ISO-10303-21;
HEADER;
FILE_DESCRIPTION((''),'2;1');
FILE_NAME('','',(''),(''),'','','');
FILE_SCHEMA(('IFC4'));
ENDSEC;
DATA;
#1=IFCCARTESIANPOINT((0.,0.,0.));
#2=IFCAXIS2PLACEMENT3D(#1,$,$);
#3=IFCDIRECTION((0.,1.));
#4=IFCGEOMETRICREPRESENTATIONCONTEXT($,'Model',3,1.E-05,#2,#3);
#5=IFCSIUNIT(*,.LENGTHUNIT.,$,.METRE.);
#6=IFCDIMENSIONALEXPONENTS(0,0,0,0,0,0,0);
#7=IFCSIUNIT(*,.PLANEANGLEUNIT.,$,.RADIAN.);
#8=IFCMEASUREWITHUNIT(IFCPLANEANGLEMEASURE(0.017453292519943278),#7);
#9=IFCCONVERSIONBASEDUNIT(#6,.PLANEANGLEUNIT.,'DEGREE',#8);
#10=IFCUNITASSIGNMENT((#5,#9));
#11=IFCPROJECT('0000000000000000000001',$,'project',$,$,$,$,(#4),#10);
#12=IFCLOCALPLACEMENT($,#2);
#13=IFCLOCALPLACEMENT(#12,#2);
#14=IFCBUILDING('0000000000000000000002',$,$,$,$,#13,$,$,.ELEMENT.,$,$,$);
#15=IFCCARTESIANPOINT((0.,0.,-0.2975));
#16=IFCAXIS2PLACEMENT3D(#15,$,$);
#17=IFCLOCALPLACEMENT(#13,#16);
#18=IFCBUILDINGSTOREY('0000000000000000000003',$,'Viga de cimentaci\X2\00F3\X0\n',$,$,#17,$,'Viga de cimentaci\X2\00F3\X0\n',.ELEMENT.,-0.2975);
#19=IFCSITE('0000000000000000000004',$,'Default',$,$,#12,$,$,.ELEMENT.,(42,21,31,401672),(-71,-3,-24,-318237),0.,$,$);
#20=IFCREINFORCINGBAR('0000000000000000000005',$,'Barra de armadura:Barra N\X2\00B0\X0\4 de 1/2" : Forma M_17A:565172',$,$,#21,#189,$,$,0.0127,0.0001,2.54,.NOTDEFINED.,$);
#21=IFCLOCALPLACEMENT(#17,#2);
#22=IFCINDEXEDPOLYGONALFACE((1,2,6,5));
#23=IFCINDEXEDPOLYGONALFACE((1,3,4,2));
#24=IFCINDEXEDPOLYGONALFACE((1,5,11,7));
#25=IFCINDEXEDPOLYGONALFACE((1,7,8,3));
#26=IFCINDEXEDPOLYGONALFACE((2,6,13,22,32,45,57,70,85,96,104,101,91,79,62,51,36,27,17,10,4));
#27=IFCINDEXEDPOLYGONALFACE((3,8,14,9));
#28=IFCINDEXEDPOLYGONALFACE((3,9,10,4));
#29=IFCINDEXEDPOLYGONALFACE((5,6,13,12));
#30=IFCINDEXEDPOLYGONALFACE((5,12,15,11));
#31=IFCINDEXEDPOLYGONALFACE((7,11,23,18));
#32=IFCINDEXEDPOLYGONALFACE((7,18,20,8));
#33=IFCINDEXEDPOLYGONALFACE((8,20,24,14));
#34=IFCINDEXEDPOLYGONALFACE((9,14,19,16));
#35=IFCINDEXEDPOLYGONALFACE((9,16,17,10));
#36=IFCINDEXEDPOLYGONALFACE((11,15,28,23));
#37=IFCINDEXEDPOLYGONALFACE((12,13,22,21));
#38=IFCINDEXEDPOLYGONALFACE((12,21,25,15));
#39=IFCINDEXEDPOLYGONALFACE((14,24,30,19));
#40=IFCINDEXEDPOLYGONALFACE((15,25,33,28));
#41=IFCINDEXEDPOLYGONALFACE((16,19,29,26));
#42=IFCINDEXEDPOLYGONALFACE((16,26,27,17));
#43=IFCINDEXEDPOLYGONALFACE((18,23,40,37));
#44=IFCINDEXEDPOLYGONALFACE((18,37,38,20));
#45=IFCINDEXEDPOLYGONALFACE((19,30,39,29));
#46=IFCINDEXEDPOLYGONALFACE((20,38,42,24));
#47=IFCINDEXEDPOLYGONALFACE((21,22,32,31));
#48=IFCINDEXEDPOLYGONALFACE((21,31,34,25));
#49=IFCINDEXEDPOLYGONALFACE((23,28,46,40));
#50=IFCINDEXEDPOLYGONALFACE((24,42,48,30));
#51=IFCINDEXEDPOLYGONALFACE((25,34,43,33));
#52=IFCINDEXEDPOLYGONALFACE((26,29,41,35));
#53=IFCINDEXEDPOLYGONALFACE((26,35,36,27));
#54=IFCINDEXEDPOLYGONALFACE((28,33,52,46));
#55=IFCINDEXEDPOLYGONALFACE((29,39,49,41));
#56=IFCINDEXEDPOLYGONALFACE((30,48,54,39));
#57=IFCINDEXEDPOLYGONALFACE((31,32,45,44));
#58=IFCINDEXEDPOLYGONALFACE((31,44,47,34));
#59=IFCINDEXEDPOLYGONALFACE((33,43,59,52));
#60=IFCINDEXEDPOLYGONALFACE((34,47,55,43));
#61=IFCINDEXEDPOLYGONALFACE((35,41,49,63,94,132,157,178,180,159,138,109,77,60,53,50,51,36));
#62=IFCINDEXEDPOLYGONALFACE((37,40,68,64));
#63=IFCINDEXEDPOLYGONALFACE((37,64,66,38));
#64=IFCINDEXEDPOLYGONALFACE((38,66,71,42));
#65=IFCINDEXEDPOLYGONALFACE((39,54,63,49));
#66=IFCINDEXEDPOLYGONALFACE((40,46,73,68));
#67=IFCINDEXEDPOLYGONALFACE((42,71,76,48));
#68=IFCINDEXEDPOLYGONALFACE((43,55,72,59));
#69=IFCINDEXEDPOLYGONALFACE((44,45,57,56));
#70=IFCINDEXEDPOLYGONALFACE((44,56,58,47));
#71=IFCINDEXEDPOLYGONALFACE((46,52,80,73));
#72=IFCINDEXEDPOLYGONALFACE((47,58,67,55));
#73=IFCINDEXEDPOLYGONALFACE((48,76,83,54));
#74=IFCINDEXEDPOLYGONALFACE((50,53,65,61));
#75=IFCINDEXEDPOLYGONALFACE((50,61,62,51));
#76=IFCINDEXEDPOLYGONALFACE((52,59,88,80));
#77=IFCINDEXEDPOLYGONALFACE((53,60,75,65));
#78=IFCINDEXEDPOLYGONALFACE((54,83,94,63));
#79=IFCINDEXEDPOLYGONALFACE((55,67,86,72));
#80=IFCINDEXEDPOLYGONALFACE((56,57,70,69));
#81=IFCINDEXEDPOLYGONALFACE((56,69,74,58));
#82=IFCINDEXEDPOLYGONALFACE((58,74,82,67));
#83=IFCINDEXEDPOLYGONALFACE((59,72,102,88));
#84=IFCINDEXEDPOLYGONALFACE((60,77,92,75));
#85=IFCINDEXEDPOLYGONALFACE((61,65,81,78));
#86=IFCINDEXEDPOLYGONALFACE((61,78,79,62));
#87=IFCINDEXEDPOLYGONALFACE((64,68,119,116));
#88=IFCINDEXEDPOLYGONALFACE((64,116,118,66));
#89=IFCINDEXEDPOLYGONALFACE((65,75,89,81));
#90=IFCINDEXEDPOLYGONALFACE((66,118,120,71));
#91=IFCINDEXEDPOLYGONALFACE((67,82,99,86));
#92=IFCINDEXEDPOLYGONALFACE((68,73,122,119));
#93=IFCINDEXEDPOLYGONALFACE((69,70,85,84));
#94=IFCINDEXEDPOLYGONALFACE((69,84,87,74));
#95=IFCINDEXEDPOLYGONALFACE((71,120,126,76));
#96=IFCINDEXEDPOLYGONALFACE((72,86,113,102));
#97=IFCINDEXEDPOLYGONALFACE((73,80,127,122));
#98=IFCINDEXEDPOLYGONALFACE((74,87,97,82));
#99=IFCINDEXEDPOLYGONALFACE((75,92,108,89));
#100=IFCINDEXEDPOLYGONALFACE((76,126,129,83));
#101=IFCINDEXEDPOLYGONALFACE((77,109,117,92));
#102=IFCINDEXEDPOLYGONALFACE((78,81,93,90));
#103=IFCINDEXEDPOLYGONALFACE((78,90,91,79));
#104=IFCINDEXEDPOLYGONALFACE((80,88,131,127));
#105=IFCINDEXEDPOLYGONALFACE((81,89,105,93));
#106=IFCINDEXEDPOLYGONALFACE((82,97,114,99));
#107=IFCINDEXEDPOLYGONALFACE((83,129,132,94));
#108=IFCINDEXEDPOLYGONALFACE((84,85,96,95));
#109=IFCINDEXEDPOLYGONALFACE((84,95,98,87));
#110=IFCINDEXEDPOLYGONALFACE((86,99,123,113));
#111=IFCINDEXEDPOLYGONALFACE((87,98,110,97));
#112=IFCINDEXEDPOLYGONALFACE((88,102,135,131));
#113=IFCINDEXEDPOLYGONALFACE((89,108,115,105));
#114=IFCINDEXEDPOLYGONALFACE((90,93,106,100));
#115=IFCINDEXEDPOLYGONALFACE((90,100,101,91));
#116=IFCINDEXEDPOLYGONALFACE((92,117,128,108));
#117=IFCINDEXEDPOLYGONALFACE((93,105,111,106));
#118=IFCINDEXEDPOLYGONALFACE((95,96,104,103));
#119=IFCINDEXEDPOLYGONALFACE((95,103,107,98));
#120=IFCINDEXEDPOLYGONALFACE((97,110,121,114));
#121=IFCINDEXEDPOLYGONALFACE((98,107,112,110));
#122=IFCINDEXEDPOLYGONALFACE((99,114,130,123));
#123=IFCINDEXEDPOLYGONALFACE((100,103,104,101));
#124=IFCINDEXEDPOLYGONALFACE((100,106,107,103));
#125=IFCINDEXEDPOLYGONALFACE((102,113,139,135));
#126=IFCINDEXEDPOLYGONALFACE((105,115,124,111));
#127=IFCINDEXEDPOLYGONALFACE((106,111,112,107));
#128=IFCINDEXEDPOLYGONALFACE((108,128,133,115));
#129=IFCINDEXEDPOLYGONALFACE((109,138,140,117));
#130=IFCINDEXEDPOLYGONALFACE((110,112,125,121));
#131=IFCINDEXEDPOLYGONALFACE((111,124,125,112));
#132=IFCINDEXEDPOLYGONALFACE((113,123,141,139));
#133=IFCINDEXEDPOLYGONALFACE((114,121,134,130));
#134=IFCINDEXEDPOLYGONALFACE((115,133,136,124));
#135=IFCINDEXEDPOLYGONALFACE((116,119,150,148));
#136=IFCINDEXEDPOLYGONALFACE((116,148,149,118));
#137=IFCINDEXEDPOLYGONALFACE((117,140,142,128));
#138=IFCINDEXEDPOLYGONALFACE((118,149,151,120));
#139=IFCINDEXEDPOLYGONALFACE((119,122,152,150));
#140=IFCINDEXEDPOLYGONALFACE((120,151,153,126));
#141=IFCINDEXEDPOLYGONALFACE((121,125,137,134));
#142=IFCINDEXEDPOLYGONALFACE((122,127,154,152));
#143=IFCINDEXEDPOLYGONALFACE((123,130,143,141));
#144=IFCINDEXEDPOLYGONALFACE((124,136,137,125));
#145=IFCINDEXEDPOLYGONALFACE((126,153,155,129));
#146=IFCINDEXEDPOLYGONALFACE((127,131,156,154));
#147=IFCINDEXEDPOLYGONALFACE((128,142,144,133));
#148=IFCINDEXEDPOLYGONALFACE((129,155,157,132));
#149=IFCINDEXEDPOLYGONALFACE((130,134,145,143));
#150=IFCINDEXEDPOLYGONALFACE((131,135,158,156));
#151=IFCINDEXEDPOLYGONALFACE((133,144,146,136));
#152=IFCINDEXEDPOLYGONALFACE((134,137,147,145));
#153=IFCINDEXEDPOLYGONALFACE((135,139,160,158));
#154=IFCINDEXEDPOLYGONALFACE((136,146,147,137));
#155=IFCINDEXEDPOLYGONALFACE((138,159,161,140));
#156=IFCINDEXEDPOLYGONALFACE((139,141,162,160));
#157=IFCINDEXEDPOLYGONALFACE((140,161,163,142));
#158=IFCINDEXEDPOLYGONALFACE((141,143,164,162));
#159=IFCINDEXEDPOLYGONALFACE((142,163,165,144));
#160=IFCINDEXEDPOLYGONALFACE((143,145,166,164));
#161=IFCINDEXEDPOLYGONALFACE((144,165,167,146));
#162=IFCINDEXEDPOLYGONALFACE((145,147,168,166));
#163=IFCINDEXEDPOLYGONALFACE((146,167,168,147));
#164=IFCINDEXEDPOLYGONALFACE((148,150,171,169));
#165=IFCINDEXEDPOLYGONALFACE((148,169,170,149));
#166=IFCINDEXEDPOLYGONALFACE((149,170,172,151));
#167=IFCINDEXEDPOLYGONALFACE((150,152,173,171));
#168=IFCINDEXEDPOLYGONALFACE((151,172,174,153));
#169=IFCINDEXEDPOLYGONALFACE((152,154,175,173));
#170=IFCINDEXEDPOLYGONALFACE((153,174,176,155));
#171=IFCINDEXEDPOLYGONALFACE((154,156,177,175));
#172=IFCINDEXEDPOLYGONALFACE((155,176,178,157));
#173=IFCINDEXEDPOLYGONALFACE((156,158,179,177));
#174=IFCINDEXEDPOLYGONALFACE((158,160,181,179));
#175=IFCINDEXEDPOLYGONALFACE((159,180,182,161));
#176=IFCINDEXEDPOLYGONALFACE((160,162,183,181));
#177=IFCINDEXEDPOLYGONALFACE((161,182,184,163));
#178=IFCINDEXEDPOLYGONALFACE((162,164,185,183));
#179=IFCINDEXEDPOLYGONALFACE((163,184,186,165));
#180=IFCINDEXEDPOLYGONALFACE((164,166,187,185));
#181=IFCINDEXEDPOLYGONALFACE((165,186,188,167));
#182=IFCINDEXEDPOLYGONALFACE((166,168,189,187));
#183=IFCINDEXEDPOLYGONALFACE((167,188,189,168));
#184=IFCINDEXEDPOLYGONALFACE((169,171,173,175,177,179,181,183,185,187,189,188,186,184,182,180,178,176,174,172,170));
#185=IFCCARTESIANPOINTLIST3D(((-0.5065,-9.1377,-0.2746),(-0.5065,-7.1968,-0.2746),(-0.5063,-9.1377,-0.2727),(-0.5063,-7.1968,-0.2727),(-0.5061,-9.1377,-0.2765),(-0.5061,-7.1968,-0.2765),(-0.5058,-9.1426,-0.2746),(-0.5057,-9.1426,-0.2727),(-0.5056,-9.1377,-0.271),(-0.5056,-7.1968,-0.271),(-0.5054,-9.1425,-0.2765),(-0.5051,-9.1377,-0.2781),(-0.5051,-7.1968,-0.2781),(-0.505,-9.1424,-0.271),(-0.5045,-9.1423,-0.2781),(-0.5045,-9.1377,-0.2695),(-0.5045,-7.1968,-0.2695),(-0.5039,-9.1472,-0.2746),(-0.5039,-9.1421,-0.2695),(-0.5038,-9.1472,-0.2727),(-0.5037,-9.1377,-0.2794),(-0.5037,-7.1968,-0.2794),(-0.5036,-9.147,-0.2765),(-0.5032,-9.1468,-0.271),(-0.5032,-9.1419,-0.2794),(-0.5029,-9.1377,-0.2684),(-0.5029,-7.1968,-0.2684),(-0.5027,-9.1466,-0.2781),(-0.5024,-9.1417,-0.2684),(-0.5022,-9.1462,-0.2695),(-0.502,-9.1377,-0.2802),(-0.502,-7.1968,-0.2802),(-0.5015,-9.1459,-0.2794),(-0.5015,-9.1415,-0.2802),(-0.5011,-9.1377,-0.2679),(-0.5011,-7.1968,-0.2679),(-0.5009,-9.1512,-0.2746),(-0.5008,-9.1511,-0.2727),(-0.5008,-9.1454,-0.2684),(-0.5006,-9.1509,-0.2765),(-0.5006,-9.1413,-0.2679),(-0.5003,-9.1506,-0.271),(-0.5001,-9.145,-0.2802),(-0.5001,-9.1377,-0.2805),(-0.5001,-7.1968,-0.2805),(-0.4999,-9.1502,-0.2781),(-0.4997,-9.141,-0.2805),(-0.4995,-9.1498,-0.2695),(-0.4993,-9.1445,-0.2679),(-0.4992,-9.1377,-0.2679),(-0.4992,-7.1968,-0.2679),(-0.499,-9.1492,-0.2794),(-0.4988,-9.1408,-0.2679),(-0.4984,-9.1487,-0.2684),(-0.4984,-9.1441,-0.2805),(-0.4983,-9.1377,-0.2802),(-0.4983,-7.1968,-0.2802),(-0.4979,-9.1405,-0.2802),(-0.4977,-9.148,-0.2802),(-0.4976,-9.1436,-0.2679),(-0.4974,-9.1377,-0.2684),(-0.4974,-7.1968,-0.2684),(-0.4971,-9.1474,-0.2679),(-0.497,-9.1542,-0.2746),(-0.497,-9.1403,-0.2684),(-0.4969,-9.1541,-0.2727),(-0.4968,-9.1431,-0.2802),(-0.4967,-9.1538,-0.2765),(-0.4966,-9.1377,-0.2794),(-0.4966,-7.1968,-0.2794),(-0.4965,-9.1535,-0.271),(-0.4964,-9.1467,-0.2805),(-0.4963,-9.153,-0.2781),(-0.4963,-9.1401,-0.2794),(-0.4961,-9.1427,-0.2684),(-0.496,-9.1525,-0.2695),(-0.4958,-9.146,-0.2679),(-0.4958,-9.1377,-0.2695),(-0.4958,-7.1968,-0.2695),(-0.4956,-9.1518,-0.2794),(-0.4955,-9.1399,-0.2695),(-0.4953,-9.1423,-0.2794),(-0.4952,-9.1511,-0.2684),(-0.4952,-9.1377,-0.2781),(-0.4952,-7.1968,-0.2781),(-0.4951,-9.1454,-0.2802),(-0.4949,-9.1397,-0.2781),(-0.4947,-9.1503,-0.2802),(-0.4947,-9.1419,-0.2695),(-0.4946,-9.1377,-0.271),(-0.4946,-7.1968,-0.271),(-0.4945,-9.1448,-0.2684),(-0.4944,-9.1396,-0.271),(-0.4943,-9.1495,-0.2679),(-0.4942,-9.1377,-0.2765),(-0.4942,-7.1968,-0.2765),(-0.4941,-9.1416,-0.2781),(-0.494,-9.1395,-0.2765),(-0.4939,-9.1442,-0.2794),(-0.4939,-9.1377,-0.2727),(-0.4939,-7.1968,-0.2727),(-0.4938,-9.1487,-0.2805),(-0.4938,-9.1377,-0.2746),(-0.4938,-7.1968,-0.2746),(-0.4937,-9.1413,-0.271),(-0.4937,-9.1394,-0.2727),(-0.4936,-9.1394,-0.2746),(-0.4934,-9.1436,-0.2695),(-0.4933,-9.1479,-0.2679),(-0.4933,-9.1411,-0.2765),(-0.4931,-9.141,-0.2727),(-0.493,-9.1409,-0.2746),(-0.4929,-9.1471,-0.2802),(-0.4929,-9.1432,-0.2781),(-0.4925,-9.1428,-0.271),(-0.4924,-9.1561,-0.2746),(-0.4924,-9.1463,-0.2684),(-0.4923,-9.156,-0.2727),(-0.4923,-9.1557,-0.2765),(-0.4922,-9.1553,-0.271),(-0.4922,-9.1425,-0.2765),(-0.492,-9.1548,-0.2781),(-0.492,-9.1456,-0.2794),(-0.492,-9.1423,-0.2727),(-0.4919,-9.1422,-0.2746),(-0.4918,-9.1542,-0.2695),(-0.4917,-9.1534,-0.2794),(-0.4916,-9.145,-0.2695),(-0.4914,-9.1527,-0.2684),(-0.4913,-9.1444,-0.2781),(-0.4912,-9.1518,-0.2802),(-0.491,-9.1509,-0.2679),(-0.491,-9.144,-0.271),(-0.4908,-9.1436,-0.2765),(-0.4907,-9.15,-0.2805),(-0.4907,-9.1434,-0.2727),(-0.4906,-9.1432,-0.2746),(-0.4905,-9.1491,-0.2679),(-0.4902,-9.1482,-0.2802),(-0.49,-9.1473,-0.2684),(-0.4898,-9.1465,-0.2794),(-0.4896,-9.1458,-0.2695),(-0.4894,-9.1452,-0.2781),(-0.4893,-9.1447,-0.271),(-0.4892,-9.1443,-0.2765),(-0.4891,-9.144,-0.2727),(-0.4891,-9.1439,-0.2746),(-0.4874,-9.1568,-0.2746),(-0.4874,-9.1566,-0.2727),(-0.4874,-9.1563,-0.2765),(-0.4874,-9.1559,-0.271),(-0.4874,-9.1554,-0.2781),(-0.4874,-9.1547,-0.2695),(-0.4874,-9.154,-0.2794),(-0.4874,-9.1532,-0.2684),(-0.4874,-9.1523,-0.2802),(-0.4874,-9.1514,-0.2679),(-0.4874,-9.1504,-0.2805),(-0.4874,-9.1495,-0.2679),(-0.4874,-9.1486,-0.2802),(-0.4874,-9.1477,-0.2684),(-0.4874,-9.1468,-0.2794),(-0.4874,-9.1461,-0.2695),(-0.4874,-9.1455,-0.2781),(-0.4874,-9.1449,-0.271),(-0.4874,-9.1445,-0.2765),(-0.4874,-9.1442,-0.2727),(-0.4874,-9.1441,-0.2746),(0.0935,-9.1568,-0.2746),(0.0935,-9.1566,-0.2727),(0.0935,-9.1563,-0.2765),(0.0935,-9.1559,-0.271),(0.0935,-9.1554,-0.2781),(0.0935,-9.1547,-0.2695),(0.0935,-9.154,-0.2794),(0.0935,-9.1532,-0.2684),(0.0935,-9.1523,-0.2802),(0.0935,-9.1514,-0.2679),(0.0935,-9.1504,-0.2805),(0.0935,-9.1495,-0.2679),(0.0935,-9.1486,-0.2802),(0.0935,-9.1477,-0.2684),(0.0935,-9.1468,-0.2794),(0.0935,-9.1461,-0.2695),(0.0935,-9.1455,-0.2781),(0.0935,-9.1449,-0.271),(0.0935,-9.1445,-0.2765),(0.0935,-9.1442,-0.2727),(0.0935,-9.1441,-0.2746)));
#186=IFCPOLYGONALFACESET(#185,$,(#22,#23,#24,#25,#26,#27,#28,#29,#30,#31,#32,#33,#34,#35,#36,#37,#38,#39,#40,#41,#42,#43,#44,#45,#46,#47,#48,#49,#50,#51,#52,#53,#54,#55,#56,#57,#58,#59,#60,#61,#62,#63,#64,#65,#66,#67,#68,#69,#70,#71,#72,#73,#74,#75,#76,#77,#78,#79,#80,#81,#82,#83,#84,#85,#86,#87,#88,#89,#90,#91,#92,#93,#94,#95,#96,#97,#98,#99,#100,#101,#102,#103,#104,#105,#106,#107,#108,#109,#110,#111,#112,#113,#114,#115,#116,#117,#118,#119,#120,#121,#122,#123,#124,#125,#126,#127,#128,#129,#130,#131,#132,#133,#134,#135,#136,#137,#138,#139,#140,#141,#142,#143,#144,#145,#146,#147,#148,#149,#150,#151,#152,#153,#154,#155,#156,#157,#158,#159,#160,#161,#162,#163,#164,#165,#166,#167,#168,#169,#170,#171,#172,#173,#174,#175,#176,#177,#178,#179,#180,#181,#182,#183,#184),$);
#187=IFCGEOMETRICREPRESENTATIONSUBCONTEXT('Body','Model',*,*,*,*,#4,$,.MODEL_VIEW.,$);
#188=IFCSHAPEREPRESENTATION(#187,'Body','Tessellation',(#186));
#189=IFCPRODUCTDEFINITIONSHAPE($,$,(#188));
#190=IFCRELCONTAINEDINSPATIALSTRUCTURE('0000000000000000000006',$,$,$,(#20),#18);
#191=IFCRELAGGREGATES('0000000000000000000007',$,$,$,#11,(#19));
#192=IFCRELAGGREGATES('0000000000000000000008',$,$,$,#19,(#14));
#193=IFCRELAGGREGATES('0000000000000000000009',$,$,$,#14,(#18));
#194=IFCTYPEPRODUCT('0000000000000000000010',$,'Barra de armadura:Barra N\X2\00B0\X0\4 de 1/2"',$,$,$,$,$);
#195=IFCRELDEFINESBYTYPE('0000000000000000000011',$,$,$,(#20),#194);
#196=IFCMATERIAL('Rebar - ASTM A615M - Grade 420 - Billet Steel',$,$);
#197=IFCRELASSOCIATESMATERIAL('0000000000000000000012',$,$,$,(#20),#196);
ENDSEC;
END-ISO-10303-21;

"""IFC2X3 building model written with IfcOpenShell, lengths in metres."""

from ifc_helpers import new_model, entity, si_unit, converted_unit, direction, frame, origin, place, context, subcontext, project, spatial, material, type_object, element, save


model = new_model("IFC2X3")

# Units and contexts
model_context = context("Model", 3, precision=1e-05, world=origin(), true_north=direction((0.0, 1.0)))
body_context = subcontext(model_context, "Body", "Model", "MODEL_VIEW")
ifc_project = project(units=[si_unit("LENGTHUNIT", "METRE"), converted_unit("PLANEANGLEUNIT", "DEGREE", entity("IfcPlaneAngleMeasure", 0.017453292519943278), si_unit("PLANEANGLEUNIT", "RADIAN"), dimensions=[0, 0, 0, 0, 0, 0, 0])], contexts=[model_context])

# Site, building, storey
site_placement = place(None, origin())
site = spatial("IfcSite", under=ifc_project, at=site_placement, Name="Default", CompositionType="ELEMENT", RefLatitude=(42, 21, 31, 401672), RefLongitude=(-71, -3, -24, -318237), RefElevation=0.0)
building_placement = place(site_placement, origin())
building = spatial("IfcBuilding", under=site, at=building_placement, CompositionType="ELEMENT")
storey_placement = place(building_placement, frame((0.0, 0.0, -0.2975)))
storey = spatial("IfcBuildingStorey", under=building, at=storey_placement, Name="Viga de cimentación", LongName="Viga de cimentación", CompositionType="ELEMENT", Elevation=-0.2975)

# Reinforcing bar
ifc_material = material(Name="Rebar - ASTM A615M - Grade 420 - Billet Steel")
type_product_1 = type_object("IfcTypeProduct", Name="Barra de armadura:Barra N°4 de 1/2\"")
reinforcing_bar_1_placement = place(storey_placement, origin())
element("IfcReinforcingBar", 1, at=reinforcing_bar_1_placement, inside=storey, type_object=type_product_1, material=ifc_material, Name="Barra de armadura:Barra N°4 de 1/2\" : Forma M_17A:565172", BarLength=2.54, BarRole="NOTDEFINED", CrossSectionArea=0.0001, NominalDiameter=0.0127, context=body_context, shape_type="AdvancedSweptSolid", body=[
    entity("IfcSweptDiskSolid", entity("IfcCompositeCurve", [entity("IfcCompositeCurveSegment", "CONTINUOUS", True, entity("IfcPolyline", [entity("IfcCartesianPoint", [-0.5001, -7.1968, -0.2741]), entity("IfcCartesianPoint", [-0.5001, -9.1377, -0.2741])])), entity("IfcCompositeCurveSegment", "CONTINUOUS", True, entity("IfcTrimmedCurve", entity("IfcCircle", entity("IfcAxis2Placement3D", entity("IfcCartesianPoint", [-0.4874, -9.1377, -0.2741]), entity("IfcDirection", [0.0, 0.0, 1.0]), entity("IfcDirection", [0.0, -1.0, 0.0])), 0.0127), [entity("IfcParameterValue", 270.0)], [entity("IfcParameterValue", 360.0)], True, "PARAMETER")), entity("IfcCompositeCurveSegment", "CONTINUOUS", True, entity("IfcPolyline", [entity("IfcCartesianPoint", [-0.4874, -9.1504, -0.2741]), entity("IfcCartesianPoint", [0.0935, -9.1504, -0.2741])]))], False), 0.0063, None, 0.0, 92.0),
])

save(model, "model.ifc")
